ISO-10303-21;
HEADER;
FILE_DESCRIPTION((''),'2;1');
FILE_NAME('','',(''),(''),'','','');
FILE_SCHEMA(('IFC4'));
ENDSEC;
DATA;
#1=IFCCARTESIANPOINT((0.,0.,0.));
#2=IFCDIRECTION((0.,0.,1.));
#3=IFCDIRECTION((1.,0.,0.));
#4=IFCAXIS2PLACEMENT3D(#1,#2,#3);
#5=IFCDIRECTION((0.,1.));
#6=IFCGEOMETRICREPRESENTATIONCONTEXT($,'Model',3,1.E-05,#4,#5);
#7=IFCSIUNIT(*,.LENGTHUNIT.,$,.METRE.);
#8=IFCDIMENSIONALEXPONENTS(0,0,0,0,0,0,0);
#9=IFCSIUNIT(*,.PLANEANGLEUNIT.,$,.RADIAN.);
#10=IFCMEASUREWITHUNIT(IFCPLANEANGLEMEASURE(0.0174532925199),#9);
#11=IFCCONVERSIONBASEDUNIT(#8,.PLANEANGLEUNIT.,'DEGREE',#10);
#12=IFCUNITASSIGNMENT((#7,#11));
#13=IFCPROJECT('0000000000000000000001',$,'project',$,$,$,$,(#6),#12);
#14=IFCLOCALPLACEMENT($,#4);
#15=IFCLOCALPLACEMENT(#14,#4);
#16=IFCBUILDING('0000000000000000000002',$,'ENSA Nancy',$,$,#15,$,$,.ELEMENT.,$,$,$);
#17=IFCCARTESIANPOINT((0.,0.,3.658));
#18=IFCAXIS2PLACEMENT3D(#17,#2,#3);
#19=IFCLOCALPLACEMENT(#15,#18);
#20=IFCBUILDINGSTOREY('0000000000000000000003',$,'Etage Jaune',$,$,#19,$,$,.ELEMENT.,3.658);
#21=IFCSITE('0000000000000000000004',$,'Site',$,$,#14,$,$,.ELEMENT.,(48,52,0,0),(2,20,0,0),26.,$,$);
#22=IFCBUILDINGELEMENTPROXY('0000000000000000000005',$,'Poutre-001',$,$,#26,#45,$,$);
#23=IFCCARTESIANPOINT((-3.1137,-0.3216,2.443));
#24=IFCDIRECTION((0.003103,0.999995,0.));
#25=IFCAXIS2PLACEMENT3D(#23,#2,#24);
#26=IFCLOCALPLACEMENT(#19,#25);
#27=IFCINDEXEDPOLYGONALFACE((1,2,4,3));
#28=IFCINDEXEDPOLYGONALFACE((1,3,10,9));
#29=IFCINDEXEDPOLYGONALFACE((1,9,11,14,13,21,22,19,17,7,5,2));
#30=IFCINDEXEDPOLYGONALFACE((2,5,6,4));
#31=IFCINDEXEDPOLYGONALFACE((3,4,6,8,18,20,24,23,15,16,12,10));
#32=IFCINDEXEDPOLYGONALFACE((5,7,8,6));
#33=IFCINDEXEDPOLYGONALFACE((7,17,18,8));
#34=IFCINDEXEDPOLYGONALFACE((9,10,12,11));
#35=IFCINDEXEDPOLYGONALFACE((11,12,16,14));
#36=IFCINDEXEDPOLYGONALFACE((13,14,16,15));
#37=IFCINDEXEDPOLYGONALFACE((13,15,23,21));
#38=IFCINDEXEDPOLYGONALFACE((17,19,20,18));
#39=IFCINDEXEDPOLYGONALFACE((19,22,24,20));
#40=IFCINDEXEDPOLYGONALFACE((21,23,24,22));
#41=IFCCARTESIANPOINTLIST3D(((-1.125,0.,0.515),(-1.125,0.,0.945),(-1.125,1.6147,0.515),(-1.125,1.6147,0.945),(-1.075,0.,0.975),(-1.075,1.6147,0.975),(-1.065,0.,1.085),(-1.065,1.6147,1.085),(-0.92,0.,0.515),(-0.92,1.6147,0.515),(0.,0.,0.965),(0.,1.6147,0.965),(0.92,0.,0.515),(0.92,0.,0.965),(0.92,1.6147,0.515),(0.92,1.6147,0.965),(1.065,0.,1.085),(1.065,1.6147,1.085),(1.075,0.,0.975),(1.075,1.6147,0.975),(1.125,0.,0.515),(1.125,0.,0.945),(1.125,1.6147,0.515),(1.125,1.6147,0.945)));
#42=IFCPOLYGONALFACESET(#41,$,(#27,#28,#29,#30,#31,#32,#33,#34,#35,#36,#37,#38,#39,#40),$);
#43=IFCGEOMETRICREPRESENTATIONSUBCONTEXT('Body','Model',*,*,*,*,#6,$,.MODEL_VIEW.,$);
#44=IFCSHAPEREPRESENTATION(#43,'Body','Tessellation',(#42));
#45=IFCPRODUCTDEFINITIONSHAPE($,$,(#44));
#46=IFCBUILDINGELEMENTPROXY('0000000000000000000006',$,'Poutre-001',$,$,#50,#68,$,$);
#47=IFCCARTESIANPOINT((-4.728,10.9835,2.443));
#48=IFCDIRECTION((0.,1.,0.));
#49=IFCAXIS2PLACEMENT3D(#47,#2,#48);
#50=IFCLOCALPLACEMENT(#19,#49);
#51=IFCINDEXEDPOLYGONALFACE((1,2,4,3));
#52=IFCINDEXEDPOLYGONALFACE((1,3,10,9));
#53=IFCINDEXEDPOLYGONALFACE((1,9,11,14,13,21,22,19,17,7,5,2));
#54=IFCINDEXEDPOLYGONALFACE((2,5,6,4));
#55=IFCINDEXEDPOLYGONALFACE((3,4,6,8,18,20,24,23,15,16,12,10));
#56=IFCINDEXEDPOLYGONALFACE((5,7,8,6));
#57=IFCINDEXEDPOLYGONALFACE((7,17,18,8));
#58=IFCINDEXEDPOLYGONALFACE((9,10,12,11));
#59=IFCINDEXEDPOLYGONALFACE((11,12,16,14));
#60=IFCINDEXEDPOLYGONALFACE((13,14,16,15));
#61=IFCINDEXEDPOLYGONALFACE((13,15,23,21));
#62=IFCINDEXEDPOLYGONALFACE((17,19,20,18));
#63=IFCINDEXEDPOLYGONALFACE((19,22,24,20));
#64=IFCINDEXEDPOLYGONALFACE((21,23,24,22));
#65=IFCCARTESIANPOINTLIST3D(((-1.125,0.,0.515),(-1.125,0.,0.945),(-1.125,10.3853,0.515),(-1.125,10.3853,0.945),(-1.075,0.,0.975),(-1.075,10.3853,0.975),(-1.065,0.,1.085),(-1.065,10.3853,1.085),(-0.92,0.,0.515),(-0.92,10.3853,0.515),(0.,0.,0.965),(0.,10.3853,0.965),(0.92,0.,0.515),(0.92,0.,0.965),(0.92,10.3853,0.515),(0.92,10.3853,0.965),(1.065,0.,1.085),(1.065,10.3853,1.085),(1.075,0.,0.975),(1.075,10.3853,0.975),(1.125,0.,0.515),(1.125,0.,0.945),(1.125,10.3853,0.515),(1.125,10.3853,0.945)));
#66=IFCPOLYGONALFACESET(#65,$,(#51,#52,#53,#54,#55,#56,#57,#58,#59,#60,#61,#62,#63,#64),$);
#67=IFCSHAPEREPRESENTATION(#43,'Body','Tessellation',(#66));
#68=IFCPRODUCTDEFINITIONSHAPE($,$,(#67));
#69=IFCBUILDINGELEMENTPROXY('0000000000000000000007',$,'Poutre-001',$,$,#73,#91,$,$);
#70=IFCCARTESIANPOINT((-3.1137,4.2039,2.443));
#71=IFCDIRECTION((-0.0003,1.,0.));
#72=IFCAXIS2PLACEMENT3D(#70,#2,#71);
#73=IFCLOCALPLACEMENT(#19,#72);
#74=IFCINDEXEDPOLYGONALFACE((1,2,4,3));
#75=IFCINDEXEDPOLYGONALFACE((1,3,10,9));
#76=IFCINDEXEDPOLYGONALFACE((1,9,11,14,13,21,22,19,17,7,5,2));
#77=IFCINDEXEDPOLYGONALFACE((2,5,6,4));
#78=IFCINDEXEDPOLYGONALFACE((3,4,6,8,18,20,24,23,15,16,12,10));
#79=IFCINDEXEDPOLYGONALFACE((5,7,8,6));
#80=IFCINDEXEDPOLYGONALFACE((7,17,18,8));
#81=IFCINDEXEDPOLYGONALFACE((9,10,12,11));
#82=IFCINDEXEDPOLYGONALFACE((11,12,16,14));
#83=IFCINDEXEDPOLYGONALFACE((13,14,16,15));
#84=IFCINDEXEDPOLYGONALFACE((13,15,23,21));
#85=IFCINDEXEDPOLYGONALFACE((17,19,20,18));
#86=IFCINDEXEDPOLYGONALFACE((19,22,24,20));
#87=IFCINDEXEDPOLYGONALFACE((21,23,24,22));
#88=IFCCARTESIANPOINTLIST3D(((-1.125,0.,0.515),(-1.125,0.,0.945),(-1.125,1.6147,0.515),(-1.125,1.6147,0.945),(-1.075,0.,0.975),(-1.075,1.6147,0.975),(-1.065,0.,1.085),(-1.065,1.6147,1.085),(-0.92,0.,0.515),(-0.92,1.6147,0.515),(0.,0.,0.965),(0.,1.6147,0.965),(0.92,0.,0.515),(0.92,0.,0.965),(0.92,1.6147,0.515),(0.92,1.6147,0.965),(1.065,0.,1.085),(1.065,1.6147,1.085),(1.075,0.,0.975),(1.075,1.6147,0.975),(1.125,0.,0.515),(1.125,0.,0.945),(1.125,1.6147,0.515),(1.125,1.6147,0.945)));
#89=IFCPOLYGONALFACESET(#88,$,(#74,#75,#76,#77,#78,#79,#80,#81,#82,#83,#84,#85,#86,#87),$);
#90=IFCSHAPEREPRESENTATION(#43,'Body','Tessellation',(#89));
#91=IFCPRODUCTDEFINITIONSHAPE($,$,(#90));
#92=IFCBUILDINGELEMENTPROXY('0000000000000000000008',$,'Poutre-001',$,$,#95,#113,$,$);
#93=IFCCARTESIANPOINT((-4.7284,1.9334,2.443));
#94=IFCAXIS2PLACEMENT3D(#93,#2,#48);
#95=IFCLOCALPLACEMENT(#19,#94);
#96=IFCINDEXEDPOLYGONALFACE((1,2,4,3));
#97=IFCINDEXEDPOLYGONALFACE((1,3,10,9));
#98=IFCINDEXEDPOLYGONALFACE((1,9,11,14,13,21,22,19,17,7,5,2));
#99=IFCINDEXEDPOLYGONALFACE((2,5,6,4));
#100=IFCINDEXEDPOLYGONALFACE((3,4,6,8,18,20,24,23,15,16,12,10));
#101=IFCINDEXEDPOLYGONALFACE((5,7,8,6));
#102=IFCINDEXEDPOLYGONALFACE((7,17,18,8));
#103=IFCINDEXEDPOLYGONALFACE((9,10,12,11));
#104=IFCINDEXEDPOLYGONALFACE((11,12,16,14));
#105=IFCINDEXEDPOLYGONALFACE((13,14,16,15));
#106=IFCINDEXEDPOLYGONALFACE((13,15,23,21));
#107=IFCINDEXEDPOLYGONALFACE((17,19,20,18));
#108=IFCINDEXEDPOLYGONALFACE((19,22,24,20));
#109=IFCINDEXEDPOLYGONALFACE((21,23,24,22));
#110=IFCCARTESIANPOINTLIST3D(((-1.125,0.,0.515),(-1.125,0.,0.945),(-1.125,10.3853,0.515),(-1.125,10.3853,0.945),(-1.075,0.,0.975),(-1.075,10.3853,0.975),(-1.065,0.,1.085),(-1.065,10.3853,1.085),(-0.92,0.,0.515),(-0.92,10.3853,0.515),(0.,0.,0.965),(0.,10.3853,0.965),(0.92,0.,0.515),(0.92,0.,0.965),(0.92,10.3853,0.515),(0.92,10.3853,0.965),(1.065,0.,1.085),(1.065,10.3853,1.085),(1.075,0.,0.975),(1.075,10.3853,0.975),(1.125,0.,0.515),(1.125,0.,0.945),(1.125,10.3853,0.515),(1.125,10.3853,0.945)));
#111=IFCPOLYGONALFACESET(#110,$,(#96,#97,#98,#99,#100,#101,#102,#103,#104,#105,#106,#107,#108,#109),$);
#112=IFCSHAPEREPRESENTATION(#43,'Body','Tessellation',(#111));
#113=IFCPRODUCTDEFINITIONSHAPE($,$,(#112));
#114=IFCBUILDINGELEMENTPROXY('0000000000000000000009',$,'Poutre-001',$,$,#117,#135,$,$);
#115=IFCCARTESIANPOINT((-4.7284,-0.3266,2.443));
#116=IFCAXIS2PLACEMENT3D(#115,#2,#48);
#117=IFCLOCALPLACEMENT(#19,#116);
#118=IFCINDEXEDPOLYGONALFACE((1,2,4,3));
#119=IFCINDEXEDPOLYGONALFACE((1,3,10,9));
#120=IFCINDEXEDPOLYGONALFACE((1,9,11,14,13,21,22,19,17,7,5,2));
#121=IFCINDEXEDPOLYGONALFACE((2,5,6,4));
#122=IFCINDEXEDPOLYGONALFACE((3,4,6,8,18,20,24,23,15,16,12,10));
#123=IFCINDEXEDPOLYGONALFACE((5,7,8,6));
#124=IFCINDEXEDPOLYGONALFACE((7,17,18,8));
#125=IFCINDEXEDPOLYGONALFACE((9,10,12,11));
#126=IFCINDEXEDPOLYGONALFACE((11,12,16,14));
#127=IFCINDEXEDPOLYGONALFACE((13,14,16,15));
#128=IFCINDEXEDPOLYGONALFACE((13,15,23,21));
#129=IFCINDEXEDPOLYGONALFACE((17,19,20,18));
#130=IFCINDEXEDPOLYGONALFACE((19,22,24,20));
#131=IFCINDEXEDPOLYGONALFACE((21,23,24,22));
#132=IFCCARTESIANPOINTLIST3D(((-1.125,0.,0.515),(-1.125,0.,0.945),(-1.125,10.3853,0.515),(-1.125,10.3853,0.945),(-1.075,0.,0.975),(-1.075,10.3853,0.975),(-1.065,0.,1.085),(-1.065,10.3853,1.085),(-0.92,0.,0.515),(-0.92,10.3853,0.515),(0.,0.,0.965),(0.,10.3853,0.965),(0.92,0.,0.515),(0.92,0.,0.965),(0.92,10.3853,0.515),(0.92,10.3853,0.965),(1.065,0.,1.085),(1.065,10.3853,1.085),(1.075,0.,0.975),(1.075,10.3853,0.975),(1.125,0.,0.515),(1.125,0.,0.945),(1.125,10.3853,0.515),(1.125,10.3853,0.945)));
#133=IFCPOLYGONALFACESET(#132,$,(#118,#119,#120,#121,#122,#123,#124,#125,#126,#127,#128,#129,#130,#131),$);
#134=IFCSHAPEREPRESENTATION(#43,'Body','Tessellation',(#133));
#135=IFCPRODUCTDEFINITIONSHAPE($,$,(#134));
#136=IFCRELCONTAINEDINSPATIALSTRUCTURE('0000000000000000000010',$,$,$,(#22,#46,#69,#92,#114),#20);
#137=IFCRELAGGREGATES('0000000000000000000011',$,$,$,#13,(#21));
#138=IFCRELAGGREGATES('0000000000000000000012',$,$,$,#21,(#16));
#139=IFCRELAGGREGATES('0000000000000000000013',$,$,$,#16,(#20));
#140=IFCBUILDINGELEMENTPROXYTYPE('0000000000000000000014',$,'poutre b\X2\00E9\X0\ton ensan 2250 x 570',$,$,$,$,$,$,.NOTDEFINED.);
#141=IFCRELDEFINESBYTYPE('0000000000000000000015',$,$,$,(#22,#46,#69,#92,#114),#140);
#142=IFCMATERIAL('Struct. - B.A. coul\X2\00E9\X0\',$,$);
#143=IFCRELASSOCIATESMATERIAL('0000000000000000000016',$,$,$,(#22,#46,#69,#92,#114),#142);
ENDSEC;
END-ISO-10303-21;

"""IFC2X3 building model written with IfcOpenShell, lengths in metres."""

from ifc_helpers import new_model, entity, si_unit, converted_unit, direction, frame, origin_with_axes, place, context, subcontext, project, spatial, polyline, outline, extrude, material, type_object, element, save


model = new_model("IFC2X3")

# Units and contexts
model_context = context("Model", 3, precision=1e-05, world=origin_with_axes(), true_north=direction((0.0, 1.0)))
body_context = subcontext(model_context, "Body", "Model", "MODEL_VIEW")
ifc_project = project(units=[si_unit("LENGTHUNIT", "METRE"), converted_unit("PLANEANGLEUNIT", "DEGREE", entity("IfcPlaneAngleMeasure", 0.0174532925199), si_unit("PLANEANGLEUNIT", "RADIAN"), dimensions=[0, 0, 0, 0, 0, 0, 0])], contexts=[model_context])

# Site, building, storey
site_placement = place(None, origin_with_axes())
site = spatial("IfcSite", under=ifc_project, at=site_placement, Name="Site", CompositionType="ELEMENT", RefLatitude=(48, 52, 0, 0), RefLongitude=(2, 20, 0, 0), RefElevation=26.0)
building_placement = place(site_placement, origin_with_axes())
building = spatial("IfcBuilding", under=site, at=building_placement, Name="ENSA Nancy", CompositionType="ELEMENT")
storey_placement = place(building_placement, frame((0.0, 0.0, 3.658), z_axis=(0.0, 0.0, 1.0), x_axis=(1.0, 0.0, 0.0)))
storey = spatial("IfcBuildingStorey", under=building, at=storey_placement, Name="Etage Jaune", CompositionType="ELEMENT", Elevation=3.658)

# Building element proxies
ifc_material_1 = material(Name="Struct. - B.A. coulé")
building_element_proxy_type_1 = type_object("IfcBuildingElementProxyType", Name="poutre béton ensan 2250 x 570", PredefinedType="NOTDEFINED")
proxy_1_placement = place(storey_placement, frame((-3.1137, -0.3216, 2.443), z_axis=(0.0, 0.0, 1.0), x_axis=(0.003103, 0.999995, 0.0)))
element("IfcBuildingElementProxy", 1, at=proxy_1_placement, inside=storey, type_object=building_element_proxy_type_1, material=ifc_material_1, Name="Poutre-001", context=body_context, shape_type="SweptSolid", body=[
    extrude(outline(polyline([(-1.065, 1.085), (-1.075, 0.975), (-1.125, 0.945), (-1.125, 0.515), (-0.92, 0.515), (0.0, 0.965), (0.92, 0.965), (0.92, 0.515), (1.125, 0.515), (1.125, 0.945), (1.075, 0.975), (1.065, 1.085), (-1.065, 1.085)])), frame((0.0, 1.6147, 0.0), z_axis=(0.0, -1.0, 0.0), x_axis=(1.0, 0.0, 0.0)), (0.0, 0.0, 1.0), 1.6147),
])
proxy_2_placement = place(storey_placement, frame((-4.728, 10.9835, 2.443), z_axis=(0.0, 0.0, 1.0), x_axis=(0.0, 1.0, 0.0)))
element("IfcBuildingElementProxy", 2, at=proxy_2_placement, inside=storey, type_object=building_element_proxy_type_1, material=ifc_material_1, Name="Poutre-001", context=body_context, shape_type="SweptSolid", body=[
    extrude(outline(polyline([(-1.065, 1.085), (-1.075, 0.975), (-1.125, 0.945), (-1.125, 0.515), (-0.92, 0.515), (0.0, 0.965), (0.92, 0.965), (0.92, 0.515), (1.125, 0.515), (1.125, 0.945), (1.075, 0.975), (1.065, 1.085), (-1.065, 1.085)])), frame((0.0, 10.3853, 0.0), z_axis=(0.0, -1.0, 0.0), x_axis=(1.0, 0.0, 0.0)), (0.0, 0.0, 1.0), 10.3853),
])
proxy_3_placement = place(storey_placement, frame((-3.1137, 4.2039, 2.443), z_axis=(0.0, 0.0, 1.0), x_axis=(-0.0003, 1.0, 0.0)))
element("IfcBuildingElementProxy", 3, at=proxy_3_placement, inside=storey, type_object=building_element_proxy_type_1, material=ifc_material_1, Name="Poutre-001", context=body_context, shape_type="SweptSolid", body=[
    extrude(outline(polyline([(-1.065, 1.085), (-1.075, 0.975), (-1.125, 0.945), (-1.125, 0.515), (-0.92, 0.515), (0.0, 0.965), (0.92, 0.965), (0.92, 0.515), (1.125, 0.515), (1.125, 0.945), (1.075, 0.975), (1.065, 1.085), (-1.065, 1.085)])), frame((0.0, 1.6147, 0.0), z_axis=(0.0, -1.0, 0.0), x_axis=(1.0, 0.0, 0.0)), (0.0, 0.0, 1.0), 1.6147),
])
for number, where, z_axis, x_axis, name in (
    (4, (-4.7284, 1.9334, 2.443), (0.0, 0.0, 1.0), (0.0, 1.0, 0.0), "Poutre-001"),
    (5, (-4.7284, -0.3266, 2.443), (0.0, 0.0, 1.0), (0.0, 1.0, 0.0), "Poutre-001"),
):
    element("IfcBuildingElementProxy", number, at=place(storey_placement, frame(where, z_axis=z_axis, x_axis=x_axis)), inside=storey, type_object=building_element_proxy_type_1, material=ifc_material_1, Name=name, context=body_context, shape_type="SweptSolid", body=[
        extrude(outline(polyline([(-1.065, 1.085), (-1.075, 0.975), (-1.125, 0.945), (-1.125, 0.515), (-0.92, 0.515), (0.0, 0.965), (0.92, 0.965), (0.92, 0.515), (1.125, 0.515), (1.125, 0.945), (1.075, 0.975), (1.065, 1.085), (-1.065, 1.085)])), frame((0.0, 10.3853, 0.0), z_axis=(0.0, -1.0, 0.0), x_axis=(1.0, 0.0, 0.0)), (0.0, 0.0, 1.0), 10.3853),
    ])

save(model, "model.ifc")
